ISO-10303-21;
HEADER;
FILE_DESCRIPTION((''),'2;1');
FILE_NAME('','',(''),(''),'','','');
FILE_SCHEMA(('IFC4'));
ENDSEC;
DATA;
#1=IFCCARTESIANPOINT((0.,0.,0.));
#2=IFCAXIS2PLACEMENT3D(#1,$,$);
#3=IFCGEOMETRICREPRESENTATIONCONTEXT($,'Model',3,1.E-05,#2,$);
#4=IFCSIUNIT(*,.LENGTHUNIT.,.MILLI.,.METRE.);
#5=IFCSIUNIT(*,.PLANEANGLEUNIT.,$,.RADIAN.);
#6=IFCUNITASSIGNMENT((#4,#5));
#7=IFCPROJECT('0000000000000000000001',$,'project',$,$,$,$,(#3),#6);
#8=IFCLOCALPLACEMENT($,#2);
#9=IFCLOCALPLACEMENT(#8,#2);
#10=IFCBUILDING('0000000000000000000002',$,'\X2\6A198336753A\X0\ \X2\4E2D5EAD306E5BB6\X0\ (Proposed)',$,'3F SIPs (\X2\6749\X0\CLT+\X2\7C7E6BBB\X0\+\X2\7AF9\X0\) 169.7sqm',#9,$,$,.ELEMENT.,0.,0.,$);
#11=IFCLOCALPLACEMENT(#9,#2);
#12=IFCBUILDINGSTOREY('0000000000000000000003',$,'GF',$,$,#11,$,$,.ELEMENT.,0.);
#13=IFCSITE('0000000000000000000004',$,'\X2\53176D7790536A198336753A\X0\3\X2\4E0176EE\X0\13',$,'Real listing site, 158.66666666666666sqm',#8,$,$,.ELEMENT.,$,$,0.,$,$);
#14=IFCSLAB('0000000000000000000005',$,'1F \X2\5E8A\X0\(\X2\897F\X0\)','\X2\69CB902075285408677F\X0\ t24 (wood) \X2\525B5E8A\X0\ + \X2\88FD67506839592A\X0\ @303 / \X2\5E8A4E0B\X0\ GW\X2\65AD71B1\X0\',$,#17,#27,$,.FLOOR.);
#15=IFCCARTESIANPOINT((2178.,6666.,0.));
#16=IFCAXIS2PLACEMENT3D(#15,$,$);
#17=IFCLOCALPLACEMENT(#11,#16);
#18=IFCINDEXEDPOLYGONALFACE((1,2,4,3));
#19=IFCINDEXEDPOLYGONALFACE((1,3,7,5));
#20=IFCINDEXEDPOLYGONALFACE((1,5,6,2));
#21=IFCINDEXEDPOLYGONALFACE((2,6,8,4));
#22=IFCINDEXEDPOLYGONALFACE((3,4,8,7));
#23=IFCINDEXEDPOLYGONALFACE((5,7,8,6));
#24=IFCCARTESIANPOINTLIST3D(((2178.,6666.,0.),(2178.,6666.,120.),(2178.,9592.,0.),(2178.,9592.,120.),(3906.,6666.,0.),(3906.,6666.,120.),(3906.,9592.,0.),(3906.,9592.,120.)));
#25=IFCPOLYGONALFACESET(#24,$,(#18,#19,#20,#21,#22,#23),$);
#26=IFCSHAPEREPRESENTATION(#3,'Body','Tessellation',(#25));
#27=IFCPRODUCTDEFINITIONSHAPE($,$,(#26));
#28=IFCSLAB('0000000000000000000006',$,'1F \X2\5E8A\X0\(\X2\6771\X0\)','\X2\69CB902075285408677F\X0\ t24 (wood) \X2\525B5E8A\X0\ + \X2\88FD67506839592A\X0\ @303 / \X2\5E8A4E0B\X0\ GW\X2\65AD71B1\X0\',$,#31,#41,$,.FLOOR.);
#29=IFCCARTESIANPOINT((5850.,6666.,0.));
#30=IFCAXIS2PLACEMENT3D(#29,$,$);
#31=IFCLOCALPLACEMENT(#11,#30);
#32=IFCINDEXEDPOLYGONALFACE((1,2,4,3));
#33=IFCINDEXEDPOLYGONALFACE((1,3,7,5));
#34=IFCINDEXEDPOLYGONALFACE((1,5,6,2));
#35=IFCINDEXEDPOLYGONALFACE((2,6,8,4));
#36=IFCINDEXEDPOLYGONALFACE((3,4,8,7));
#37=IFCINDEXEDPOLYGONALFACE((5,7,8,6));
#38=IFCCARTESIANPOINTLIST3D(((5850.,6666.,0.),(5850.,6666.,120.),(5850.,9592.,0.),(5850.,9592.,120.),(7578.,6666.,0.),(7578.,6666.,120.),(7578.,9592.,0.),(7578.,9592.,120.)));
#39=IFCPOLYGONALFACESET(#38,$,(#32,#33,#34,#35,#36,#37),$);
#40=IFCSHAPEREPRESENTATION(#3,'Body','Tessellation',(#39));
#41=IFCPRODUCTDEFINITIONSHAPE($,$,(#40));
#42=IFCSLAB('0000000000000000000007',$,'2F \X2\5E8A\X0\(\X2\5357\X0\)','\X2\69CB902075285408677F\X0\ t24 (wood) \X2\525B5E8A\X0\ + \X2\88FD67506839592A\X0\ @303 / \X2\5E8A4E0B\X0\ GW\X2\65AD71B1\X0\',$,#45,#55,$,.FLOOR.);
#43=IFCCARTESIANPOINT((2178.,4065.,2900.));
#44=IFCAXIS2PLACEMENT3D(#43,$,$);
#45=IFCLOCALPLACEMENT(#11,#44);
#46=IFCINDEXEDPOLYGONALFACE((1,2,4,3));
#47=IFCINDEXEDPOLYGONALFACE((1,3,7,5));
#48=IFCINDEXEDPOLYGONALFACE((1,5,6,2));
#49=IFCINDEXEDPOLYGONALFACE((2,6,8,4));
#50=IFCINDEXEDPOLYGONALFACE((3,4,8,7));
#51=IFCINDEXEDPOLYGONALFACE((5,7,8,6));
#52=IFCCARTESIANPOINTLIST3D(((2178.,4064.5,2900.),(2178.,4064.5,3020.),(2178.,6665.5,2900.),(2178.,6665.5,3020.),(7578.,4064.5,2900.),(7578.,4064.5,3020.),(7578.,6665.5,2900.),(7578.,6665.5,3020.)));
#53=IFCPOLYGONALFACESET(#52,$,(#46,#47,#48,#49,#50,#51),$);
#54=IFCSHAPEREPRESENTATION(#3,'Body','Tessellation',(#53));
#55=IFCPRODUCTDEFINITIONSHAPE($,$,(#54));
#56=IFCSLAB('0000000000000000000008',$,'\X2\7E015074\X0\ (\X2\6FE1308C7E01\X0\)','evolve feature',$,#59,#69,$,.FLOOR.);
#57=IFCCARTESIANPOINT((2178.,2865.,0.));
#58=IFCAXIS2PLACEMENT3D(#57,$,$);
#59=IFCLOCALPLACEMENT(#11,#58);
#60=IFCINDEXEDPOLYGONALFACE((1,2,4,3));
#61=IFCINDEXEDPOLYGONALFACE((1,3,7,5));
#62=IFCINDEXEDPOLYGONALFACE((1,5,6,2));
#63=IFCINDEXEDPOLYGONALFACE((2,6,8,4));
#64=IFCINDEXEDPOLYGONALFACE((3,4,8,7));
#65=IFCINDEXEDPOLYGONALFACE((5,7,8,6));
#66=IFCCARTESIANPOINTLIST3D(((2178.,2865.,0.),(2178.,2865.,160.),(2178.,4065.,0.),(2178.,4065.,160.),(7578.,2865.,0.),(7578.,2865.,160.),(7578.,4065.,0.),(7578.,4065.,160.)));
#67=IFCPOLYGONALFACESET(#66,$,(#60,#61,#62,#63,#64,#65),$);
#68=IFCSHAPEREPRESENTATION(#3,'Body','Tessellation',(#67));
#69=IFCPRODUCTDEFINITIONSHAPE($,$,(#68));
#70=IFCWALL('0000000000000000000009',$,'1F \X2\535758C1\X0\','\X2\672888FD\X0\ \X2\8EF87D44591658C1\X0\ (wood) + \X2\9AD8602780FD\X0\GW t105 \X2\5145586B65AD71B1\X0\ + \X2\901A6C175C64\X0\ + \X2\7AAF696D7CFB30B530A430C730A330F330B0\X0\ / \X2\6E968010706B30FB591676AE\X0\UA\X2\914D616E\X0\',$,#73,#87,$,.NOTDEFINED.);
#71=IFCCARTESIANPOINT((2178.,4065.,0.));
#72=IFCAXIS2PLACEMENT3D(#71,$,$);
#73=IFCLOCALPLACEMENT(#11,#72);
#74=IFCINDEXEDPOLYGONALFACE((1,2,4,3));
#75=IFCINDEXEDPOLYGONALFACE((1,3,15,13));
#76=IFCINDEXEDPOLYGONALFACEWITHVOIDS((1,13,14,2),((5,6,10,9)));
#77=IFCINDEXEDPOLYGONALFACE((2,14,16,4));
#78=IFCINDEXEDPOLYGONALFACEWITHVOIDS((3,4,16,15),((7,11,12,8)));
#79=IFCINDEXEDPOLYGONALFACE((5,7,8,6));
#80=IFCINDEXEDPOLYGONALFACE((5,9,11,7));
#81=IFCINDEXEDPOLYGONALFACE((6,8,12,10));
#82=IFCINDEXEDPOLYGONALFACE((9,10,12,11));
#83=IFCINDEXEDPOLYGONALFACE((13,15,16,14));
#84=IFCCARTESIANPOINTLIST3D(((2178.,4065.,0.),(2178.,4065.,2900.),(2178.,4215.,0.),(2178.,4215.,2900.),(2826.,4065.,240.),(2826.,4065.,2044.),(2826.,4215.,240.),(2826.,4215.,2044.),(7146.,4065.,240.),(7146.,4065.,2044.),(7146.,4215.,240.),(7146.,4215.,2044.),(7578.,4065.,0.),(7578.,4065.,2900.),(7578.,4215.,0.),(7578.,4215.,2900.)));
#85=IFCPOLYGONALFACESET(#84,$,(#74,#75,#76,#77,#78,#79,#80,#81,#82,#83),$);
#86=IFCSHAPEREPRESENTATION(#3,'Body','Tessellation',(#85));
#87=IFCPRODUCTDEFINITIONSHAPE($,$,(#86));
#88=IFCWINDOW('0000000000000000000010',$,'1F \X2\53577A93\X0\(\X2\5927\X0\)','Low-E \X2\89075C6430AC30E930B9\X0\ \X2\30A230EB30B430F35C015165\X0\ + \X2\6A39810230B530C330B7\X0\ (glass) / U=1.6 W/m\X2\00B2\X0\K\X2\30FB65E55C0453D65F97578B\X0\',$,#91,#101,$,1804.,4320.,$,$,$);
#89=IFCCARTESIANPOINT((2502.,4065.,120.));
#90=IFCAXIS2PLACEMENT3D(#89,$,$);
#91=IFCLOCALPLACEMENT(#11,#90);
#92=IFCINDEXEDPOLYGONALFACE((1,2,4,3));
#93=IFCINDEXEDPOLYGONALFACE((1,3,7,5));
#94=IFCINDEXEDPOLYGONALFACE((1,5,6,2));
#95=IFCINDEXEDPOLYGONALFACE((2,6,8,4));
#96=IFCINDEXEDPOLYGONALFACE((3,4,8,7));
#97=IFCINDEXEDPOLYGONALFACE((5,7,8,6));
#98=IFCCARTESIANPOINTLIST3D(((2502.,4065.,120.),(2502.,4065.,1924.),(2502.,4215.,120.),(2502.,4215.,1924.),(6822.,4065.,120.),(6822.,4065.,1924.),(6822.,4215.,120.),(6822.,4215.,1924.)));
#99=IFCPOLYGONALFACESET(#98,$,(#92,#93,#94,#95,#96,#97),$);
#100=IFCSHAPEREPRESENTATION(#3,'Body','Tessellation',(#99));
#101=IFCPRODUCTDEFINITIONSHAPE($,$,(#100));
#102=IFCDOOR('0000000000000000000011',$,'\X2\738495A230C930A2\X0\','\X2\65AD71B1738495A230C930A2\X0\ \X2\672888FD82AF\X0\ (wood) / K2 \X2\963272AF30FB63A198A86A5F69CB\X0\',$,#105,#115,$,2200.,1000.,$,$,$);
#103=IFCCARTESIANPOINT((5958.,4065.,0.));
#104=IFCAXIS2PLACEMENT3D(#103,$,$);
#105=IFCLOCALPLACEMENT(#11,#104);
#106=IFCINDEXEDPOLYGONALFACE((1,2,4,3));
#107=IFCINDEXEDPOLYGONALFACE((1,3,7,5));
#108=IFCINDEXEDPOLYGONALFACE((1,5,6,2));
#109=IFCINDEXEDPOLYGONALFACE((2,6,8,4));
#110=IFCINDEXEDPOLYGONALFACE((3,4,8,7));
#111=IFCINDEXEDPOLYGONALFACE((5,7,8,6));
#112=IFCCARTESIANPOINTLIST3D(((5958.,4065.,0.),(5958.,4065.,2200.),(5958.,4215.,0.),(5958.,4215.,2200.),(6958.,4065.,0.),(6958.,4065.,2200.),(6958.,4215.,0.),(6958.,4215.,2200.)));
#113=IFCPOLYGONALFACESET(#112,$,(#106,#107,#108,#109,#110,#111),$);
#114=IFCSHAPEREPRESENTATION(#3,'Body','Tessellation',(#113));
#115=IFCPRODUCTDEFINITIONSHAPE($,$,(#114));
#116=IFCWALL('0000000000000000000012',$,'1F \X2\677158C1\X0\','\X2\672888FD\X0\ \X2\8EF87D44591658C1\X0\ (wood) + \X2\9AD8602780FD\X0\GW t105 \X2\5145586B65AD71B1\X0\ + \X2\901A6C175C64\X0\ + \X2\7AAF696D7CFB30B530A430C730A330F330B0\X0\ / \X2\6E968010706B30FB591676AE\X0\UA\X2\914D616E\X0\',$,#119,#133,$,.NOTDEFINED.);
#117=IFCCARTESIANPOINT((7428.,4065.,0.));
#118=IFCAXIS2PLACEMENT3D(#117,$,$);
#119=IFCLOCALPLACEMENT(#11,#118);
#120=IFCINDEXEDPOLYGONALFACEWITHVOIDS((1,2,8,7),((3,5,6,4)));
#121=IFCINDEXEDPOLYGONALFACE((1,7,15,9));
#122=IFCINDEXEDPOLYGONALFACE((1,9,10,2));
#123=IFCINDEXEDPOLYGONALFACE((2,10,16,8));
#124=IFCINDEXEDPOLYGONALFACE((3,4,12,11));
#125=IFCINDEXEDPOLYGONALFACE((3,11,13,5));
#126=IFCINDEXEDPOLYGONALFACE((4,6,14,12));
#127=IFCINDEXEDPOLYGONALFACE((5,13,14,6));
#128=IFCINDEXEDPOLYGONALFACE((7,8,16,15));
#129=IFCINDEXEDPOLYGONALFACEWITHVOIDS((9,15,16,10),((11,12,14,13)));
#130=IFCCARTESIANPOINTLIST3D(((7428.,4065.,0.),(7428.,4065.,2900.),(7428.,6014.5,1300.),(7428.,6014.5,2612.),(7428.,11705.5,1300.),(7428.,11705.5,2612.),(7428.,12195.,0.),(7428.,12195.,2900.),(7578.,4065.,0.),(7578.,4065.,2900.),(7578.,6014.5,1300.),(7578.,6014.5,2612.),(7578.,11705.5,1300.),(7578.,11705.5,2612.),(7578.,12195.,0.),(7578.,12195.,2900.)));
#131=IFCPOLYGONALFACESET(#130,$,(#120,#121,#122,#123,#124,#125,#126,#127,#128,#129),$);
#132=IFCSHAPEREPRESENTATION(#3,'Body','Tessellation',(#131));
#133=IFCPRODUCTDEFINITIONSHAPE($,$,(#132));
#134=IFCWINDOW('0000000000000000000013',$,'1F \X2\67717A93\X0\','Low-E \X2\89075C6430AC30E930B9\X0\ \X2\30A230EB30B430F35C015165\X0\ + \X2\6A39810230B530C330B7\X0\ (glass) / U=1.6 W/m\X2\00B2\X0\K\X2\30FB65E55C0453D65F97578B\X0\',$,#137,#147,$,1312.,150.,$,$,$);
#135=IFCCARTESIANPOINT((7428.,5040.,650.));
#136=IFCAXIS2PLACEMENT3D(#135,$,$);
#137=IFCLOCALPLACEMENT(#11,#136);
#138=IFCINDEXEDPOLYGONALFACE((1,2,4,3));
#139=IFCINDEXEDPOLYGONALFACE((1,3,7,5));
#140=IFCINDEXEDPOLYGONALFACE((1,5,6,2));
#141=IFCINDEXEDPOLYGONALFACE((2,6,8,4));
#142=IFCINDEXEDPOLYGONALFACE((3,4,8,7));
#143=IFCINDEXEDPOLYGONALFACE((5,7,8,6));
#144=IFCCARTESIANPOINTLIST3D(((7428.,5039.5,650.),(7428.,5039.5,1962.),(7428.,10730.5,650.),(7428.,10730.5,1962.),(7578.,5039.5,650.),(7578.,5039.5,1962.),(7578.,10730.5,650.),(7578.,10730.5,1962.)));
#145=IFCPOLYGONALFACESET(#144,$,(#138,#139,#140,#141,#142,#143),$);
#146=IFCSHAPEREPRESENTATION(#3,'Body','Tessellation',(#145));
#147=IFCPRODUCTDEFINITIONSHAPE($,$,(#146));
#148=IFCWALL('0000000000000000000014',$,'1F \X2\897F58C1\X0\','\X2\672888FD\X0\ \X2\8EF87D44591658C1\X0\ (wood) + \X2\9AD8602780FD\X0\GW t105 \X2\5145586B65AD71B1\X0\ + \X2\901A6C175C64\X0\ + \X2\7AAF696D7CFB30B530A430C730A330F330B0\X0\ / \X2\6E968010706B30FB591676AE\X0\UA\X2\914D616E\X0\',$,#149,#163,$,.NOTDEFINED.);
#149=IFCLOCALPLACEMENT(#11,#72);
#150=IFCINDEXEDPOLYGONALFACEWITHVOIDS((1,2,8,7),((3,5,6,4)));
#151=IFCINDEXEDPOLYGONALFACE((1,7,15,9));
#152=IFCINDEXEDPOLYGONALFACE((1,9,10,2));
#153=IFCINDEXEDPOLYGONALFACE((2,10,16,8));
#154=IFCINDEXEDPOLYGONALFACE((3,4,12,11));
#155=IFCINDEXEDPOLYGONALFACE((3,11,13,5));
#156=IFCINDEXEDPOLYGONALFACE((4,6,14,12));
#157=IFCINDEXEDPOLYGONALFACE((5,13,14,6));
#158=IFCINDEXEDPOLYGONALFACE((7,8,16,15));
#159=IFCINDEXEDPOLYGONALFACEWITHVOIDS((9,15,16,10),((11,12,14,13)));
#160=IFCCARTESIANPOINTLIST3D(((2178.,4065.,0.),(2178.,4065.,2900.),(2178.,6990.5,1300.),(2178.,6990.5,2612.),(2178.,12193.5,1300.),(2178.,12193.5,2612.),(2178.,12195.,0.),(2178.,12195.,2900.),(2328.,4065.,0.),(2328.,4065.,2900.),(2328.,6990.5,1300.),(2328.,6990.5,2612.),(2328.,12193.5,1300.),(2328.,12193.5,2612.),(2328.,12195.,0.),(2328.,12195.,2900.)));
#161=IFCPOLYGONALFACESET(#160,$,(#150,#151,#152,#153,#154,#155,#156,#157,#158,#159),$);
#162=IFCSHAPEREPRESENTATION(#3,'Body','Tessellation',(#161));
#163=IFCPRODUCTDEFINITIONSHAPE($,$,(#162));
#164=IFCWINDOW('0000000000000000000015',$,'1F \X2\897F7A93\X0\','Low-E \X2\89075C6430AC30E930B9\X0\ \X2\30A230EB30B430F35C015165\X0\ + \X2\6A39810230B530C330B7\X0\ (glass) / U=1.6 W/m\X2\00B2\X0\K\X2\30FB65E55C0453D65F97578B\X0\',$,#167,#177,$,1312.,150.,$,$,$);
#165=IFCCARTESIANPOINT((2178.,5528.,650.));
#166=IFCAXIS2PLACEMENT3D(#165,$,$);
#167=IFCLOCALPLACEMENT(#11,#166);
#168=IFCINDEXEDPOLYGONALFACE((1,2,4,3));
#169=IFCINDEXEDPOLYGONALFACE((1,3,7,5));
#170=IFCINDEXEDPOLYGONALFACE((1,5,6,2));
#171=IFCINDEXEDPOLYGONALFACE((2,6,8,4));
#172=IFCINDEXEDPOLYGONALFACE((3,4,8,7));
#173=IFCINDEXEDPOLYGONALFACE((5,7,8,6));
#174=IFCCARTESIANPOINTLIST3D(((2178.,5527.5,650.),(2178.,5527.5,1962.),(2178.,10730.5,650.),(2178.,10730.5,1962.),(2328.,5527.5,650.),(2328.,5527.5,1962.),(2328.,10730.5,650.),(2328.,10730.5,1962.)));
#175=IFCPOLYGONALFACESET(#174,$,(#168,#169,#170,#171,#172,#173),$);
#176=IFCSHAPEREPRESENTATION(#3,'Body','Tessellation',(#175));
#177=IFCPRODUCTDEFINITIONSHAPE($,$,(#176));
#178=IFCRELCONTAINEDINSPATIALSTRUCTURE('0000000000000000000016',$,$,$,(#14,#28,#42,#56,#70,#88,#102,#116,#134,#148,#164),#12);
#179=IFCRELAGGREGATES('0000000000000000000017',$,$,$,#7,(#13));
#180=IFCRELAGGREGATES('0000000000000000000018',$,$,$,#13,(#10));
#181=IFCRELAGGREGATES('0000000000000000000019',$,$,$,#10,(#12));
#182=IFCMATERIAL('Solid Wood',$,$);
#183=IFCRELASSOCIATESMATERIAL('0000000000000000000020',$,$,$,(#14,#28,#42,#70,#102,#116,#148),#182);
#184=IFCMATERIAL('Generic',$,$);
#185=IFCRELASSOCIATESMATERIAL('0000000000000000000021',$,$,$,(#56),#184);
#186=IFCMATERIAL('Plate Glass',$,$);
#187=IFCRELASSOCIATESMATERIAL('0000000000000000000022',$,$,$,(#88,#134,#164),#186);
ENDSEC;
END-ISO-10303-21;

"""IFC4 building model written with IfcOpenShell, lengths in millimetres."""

from ifc_helpers import new_model, si_unit, frame, frame_2d, origin, place, context, project, spatial, rectangle, extrude, material, element, fill, save


model = new_model("IFC4")

# Units and contexts
model_context = context("Model", 3, precision=1e-05, world=origin())
ifc_project = project(units=[si_unit("LENGTHUNIT", "METRE", prefix="MILLI"), si_unit("PLANEANGLEUNIT", "RADIAN")], contexts=[model_context])

# Site, building, storey
site_placement = place(None, origin())
site = spatial("IfcSite", under=ifc_project, at=site_placement, Name="北海道標茶町3丁目13", ObjectType="Real listing site, 158.66666666666666sqm", CompositionType="ELEMENT", RefElevation=0.0)
building_placement = place(site_placement, origin())
building = spatial("IfcBuilding", under=site, at=building_placement, Name="標茶町 中庭の家 (Proposed)", ObjectType="3F SIPs (杉CLT+籾殻+竹) 169.7sqm", CompositionType="ELEMENT", ElevationOfRefHeight=0.0, ElevationOfTerrain=0.0)
storey_placement = place(building_placement, origin())
storey = spatial("IfcBuildingStorey", under=building, at=storey_placement, Name="GF", CompositionType="ELEMENT", Elevation=0.0)

# Slabs
ifc_material_1 = material(Name="Solid Wood")
slab_1_placement = place(storey_placement, frame((2178.0, 6666.0, 0.0)))
element("IfcSlab", 1, at=slab_1_placement, inside=storey, material=ifc_material_1, Name="1F 床(西)", Description="構造用合板 t24 (wood) 剛床 + 製材根太 @303 / 床下 GW断熱", PredefinedType="FLOOR", context=model_context, shape_type="SweptSolid", body=[
    extrude(rectangle(XDim=1728.0, YDim=2926.0, at=frame_2d((864.0, 1463.0))), frame((2178.0, 6666.0, 0.0)), (0.0, 0.0, 1.0), 120.0),
])
slab_2_placement = place(storey_placement, frame((5850.0, 6666.0, 0.0)))
element("IfcSlab", 2, at=slab_2_placement, inside=storey, material=ifc_material_1, Name="1F 床(東)", Description="構造用合板 t24 (wood) 剛床 + 製材根太 @303 / 床下 GW断熱", PredefinedType="FLOOR", context=model_context, shape_type="SweptSolid", body=[
    extrude(rectangle(XDim=1728.0, YDim=2926.0, at=frame_2d((864.0, 1463.0))), frame((5850.0, 6666.0, 0.0)), (0.0, 0.0, 1.0), 120.0),
])
slab_3_placement = place(storey_placement, frame((2178.0, 4065.0, 2900.0)))
element("IfcSlab", 3, at=slab_3_placement, inside=storey, material=ifc_material_1, Name="2F 床(南)", Description="構造用合板 t24 (wood) 剛床 + 製材根太 @303 / 床下 GW断熱", PredefinedType="FLOOR", context=model_context, shape_type="SweptSolid", body=[
    extrude(rectangle(XDim=5400.0, YDim=2601.0, at=frame_2d((2700.0, 1300.0))), frame((2178.0, 4065.0, 2900.0)), (0.0, 0.0, 1.0), 120.0),
])
ifc_material_2 = material(Name="Generic")
slab_4_placement = place(storey_placement, frame((2178.0, 2865.0, 0.0)))
element("IfcSlab", 4, at=slab_4_placement, inside=storey, material=ifc_material_2, Name="縁側 (濡れ縁)", Description="evolve feature", PredefinedType="FLOOR", context=model_context, shape_type="SweptSolid", body=[
    extrude(rectangle(XDim=5400.0, YDim=1200.0, at=frame_2d((2700.0, 600.0))), frame((2178.0, 2865.0, 0.0)), (0.0, 0.0, 1.0), 160.0),
])

# Wall, openings, window, door
wall_1_placement = place(storey_placement, frame((2178.0, 4065.0, 0.0)))
wall_1 = element("IfcWall", 5, at=wall_1_placement, inside=storey, material=ifc_material_1, Name="1F 南壁", Description="木製 軸組外壁 (wood) + 高性能GW t105 充填断熱 + 通気層 + 窯業系サイディング / 準耐火・外皮UA配慮", PredefinedType="NOTDEFINED", context=model_context, shape_type="SweptSolid", body=[
    extrude(rectangle(XDim=5400.0, YDim=150.0, at=frame_2d((2700.0, 75.0))), frame((2178.0, 4065.0, 0.0)), (0.0, 0.0, 1.0), 2900.0),
])
opening_1_placement = place(storey_placement, frame((2502.0, 4065.0, 120.0)))
opening_1 = element("IfcOpeningElement", 6, at=opening_1_placement, cuts=wall_1, PredefinedType="NOTDEFINED", context=model_context, shape_type="SweptSolid", body=[
    extrude(rectangle(XDim=4320.0, YDim=150.0, at=frame_2d((2160.0, 75.0))), frame((2502.0, 4065.0, 120.0)), (0.0, 0.0, 1.0), 1804.0),
])
opening_2_placement = place(storey_placement, frame((5958.0, 4065.0, 0.0)))
opening_2 = element("IfcOpeningElement", 7, at=opening_2_placement, cuts=wall_1, PredefinedType="NOTDEFINED", context=model_context, shape_type="SweptSolid", body=[
    extrude(rectangle(XDim=1000.0, YDim=150.0, at=frame_2d((500.0, 75.0))), frame((5958.0, 4065.0, 0.0)), (0.0, 0.0, 1.0), 2200.0),
])
ifc_material_3 = material(Name="Plate Glass")
window_1_placement = place(storey_placement, frame((2502.0, 4065.0, 120.0)))
window_1 = element("IfcWindow", 8, at=window_1_placement, inside=storey, material=ifc_material_3, Name="1F 南窓(大)", Description="Low-E 複層ガラス アルゴン封入 + 樹脂サッシ (glass) / U=1.6 W/m²K・日射取得型", OverallHeight=1804.0, OverallWidth=4320.0, context=model_context, shape_type="SweptSolid", body=[
    extrude(rectangle(XDim=4320.0, YDim=150.0, at=frame_2d((2160.0, 75.0))), frame((2502.0, 4065.0, 120.0)), (0.0, 0.0, 1.0), 1804.0),
])
fill(opening_1, window_1)
door_placement = place(storey_placement, frame((5958.0, 4065.0, 0.0)))
door = element("IfcDoor", 9, at=door_placement, inside=storey, material=ifc_material_1, Name="玄関ドア", Description="断熱玄関ドア 木製芯 (wood) / K2 防犯・採風機構", OverallHeight=2200.0, OverallWidth=1000.0, context=model_context, shape_type="SweptSolid", body=[
    extrude(rectangle(XDim=1000.0, YDim=150.0, at=frame_2d((500.0, 75.0))), frame((5958.0, 4065.0, 0.0)), (0.0, 0.0, 1.0), 2200.0),
])
fill(opening_2, door)

# Walls, openings, windows
wall_2_placement = place(storey_placement, frame((7428.0, 4065.0, 0.0)))
wall_2 = element("IfcWall", 10, at=wall_2_placement, inside=storey, material=ifc_material_1, Name="1F 東壁", Description="木製 軸組外壁 (wood) + 高性能GW t105 充填断熱 + 通気層 + 窯業系サイディング / 準耐火・外皮UA配慮", PredefinedType="NOTDEFINED", context=model_context, shape_type="SweptSolid", body=[
    extrude(rectangle(XDim=150.0, YDim=8130.0, at=frame_2d((75.0, 4065.0))), frame((7428.0, 4065.0, 0.0)), (0.0, 0.0, 1.0), 2900.0),
])
opening_3_placement = place(storey_placement, frame((7428.0, 5040.0, 650.0)))
opening_3 = element("IfcOpeningElement", 11, at=opening_3_placement, cuts=wall_2, PredefinedType="NOTDEFINED", context=model_context, shape_type="SweptSolid", body=[
    extrude(rectangle(XDim=150.0, YDim=5691.0, at=frame_2d((75.0, 2845.0))), frame((7428.0, 5040.0, 650.0)), (0.0, 0.0, 1.0), 1312.0),
])
window_2_placement = place(storey_placement, frame((7428.0, 5040.0, 650.0)))
window_2 = element("IfcWindow", 12, at=window_2_placement, inside=storey, material=ifc_material_3, Name="1F 東窓", Description="Low-E 複層ガラス アルゴン封入 + 樹脂サッシ (glass) / U=1.6 W/m²K・日射取得型", OverallHeight=1312.0, OverallWidth=150.0, context=model_context, shape_type="SweptSolid", body=[
    extrude(rectangle(XDim=150.0, YDim=5691.0, at=frame_2d((75.0, 2845.0))), frame((7428.0, 5040.0, 650.0)), (0.0, 0.0, 1.0), 1312.0),
])
fill(opening_3, window_2)
wall_3_placement = place(storey_placement, frame((2178.0, 4065.0, 0.0)))
wall_3 = element("IfcWall", 13, at=wall_3_placement, inside=storey, material=ifc_material_1, Name="1F 西壁", Description="木製 軸組外壁 (wood) + 高性能GW t105 充填断熱 + 通気層 + 窯業系サイディング / 準耐火・外皮UA配慮", PredefinedType="NOTDEFINED", context=model_context, shape_type="SweptSolid", body=[
    extrude(rectangle(XDim=150.0, YDim=8130.0, at=frame_2d((75.0, 4065.0))), frame((2178.0, 4065.0, 0.0)), (0.0, 0.0, 1.0), 2900.0),
])
opening_4_placement = place(storey_placement, frame((2178.0, 5528.0, 650.0)))
opening_4 = element("IfcOpeningElement", 14, at=opening_4_placement, cuts=wall_3, PredefinedType="NOTDEFINED", context=model_context, shape_type="SweptSolid", body=[
    extrude(rectangle(XDim=150.0, YDim=5203.0, at=frame_2d((75.0, 2601.0))), frame((2178.0, 5528.0, 650.0)), (0.0, 0.0, 1.0), 1312.0),
])
window_3_placement = place(storey_placement, frame((2178.0, 5528.0, 650.0)))
window_3 = element("IfcWindow", 15, at=window_3_placement, inside=storey, material=ifc_material_3, Name="1F 西窓", Description="Low-E 複層ガラス アルゴン封入 + 樹脂サッシ (glass) / U=1.6 W/m²K・日射取得型", OverallHeight=1312.0, OverallWidth=150.0, context=model_context, shape_type="SweptSolid", body=[
    extrude(rectangle(XDim=150.0, YDim=5203.0, at=frame_2d((75.0, 2601.0))), frame((2178.0, 5528.0, 650.0)), (0.0, 0.0, 1.0), 1312.0),
])
fill(opening_4, window_3)

save(model, "model.ifc")
